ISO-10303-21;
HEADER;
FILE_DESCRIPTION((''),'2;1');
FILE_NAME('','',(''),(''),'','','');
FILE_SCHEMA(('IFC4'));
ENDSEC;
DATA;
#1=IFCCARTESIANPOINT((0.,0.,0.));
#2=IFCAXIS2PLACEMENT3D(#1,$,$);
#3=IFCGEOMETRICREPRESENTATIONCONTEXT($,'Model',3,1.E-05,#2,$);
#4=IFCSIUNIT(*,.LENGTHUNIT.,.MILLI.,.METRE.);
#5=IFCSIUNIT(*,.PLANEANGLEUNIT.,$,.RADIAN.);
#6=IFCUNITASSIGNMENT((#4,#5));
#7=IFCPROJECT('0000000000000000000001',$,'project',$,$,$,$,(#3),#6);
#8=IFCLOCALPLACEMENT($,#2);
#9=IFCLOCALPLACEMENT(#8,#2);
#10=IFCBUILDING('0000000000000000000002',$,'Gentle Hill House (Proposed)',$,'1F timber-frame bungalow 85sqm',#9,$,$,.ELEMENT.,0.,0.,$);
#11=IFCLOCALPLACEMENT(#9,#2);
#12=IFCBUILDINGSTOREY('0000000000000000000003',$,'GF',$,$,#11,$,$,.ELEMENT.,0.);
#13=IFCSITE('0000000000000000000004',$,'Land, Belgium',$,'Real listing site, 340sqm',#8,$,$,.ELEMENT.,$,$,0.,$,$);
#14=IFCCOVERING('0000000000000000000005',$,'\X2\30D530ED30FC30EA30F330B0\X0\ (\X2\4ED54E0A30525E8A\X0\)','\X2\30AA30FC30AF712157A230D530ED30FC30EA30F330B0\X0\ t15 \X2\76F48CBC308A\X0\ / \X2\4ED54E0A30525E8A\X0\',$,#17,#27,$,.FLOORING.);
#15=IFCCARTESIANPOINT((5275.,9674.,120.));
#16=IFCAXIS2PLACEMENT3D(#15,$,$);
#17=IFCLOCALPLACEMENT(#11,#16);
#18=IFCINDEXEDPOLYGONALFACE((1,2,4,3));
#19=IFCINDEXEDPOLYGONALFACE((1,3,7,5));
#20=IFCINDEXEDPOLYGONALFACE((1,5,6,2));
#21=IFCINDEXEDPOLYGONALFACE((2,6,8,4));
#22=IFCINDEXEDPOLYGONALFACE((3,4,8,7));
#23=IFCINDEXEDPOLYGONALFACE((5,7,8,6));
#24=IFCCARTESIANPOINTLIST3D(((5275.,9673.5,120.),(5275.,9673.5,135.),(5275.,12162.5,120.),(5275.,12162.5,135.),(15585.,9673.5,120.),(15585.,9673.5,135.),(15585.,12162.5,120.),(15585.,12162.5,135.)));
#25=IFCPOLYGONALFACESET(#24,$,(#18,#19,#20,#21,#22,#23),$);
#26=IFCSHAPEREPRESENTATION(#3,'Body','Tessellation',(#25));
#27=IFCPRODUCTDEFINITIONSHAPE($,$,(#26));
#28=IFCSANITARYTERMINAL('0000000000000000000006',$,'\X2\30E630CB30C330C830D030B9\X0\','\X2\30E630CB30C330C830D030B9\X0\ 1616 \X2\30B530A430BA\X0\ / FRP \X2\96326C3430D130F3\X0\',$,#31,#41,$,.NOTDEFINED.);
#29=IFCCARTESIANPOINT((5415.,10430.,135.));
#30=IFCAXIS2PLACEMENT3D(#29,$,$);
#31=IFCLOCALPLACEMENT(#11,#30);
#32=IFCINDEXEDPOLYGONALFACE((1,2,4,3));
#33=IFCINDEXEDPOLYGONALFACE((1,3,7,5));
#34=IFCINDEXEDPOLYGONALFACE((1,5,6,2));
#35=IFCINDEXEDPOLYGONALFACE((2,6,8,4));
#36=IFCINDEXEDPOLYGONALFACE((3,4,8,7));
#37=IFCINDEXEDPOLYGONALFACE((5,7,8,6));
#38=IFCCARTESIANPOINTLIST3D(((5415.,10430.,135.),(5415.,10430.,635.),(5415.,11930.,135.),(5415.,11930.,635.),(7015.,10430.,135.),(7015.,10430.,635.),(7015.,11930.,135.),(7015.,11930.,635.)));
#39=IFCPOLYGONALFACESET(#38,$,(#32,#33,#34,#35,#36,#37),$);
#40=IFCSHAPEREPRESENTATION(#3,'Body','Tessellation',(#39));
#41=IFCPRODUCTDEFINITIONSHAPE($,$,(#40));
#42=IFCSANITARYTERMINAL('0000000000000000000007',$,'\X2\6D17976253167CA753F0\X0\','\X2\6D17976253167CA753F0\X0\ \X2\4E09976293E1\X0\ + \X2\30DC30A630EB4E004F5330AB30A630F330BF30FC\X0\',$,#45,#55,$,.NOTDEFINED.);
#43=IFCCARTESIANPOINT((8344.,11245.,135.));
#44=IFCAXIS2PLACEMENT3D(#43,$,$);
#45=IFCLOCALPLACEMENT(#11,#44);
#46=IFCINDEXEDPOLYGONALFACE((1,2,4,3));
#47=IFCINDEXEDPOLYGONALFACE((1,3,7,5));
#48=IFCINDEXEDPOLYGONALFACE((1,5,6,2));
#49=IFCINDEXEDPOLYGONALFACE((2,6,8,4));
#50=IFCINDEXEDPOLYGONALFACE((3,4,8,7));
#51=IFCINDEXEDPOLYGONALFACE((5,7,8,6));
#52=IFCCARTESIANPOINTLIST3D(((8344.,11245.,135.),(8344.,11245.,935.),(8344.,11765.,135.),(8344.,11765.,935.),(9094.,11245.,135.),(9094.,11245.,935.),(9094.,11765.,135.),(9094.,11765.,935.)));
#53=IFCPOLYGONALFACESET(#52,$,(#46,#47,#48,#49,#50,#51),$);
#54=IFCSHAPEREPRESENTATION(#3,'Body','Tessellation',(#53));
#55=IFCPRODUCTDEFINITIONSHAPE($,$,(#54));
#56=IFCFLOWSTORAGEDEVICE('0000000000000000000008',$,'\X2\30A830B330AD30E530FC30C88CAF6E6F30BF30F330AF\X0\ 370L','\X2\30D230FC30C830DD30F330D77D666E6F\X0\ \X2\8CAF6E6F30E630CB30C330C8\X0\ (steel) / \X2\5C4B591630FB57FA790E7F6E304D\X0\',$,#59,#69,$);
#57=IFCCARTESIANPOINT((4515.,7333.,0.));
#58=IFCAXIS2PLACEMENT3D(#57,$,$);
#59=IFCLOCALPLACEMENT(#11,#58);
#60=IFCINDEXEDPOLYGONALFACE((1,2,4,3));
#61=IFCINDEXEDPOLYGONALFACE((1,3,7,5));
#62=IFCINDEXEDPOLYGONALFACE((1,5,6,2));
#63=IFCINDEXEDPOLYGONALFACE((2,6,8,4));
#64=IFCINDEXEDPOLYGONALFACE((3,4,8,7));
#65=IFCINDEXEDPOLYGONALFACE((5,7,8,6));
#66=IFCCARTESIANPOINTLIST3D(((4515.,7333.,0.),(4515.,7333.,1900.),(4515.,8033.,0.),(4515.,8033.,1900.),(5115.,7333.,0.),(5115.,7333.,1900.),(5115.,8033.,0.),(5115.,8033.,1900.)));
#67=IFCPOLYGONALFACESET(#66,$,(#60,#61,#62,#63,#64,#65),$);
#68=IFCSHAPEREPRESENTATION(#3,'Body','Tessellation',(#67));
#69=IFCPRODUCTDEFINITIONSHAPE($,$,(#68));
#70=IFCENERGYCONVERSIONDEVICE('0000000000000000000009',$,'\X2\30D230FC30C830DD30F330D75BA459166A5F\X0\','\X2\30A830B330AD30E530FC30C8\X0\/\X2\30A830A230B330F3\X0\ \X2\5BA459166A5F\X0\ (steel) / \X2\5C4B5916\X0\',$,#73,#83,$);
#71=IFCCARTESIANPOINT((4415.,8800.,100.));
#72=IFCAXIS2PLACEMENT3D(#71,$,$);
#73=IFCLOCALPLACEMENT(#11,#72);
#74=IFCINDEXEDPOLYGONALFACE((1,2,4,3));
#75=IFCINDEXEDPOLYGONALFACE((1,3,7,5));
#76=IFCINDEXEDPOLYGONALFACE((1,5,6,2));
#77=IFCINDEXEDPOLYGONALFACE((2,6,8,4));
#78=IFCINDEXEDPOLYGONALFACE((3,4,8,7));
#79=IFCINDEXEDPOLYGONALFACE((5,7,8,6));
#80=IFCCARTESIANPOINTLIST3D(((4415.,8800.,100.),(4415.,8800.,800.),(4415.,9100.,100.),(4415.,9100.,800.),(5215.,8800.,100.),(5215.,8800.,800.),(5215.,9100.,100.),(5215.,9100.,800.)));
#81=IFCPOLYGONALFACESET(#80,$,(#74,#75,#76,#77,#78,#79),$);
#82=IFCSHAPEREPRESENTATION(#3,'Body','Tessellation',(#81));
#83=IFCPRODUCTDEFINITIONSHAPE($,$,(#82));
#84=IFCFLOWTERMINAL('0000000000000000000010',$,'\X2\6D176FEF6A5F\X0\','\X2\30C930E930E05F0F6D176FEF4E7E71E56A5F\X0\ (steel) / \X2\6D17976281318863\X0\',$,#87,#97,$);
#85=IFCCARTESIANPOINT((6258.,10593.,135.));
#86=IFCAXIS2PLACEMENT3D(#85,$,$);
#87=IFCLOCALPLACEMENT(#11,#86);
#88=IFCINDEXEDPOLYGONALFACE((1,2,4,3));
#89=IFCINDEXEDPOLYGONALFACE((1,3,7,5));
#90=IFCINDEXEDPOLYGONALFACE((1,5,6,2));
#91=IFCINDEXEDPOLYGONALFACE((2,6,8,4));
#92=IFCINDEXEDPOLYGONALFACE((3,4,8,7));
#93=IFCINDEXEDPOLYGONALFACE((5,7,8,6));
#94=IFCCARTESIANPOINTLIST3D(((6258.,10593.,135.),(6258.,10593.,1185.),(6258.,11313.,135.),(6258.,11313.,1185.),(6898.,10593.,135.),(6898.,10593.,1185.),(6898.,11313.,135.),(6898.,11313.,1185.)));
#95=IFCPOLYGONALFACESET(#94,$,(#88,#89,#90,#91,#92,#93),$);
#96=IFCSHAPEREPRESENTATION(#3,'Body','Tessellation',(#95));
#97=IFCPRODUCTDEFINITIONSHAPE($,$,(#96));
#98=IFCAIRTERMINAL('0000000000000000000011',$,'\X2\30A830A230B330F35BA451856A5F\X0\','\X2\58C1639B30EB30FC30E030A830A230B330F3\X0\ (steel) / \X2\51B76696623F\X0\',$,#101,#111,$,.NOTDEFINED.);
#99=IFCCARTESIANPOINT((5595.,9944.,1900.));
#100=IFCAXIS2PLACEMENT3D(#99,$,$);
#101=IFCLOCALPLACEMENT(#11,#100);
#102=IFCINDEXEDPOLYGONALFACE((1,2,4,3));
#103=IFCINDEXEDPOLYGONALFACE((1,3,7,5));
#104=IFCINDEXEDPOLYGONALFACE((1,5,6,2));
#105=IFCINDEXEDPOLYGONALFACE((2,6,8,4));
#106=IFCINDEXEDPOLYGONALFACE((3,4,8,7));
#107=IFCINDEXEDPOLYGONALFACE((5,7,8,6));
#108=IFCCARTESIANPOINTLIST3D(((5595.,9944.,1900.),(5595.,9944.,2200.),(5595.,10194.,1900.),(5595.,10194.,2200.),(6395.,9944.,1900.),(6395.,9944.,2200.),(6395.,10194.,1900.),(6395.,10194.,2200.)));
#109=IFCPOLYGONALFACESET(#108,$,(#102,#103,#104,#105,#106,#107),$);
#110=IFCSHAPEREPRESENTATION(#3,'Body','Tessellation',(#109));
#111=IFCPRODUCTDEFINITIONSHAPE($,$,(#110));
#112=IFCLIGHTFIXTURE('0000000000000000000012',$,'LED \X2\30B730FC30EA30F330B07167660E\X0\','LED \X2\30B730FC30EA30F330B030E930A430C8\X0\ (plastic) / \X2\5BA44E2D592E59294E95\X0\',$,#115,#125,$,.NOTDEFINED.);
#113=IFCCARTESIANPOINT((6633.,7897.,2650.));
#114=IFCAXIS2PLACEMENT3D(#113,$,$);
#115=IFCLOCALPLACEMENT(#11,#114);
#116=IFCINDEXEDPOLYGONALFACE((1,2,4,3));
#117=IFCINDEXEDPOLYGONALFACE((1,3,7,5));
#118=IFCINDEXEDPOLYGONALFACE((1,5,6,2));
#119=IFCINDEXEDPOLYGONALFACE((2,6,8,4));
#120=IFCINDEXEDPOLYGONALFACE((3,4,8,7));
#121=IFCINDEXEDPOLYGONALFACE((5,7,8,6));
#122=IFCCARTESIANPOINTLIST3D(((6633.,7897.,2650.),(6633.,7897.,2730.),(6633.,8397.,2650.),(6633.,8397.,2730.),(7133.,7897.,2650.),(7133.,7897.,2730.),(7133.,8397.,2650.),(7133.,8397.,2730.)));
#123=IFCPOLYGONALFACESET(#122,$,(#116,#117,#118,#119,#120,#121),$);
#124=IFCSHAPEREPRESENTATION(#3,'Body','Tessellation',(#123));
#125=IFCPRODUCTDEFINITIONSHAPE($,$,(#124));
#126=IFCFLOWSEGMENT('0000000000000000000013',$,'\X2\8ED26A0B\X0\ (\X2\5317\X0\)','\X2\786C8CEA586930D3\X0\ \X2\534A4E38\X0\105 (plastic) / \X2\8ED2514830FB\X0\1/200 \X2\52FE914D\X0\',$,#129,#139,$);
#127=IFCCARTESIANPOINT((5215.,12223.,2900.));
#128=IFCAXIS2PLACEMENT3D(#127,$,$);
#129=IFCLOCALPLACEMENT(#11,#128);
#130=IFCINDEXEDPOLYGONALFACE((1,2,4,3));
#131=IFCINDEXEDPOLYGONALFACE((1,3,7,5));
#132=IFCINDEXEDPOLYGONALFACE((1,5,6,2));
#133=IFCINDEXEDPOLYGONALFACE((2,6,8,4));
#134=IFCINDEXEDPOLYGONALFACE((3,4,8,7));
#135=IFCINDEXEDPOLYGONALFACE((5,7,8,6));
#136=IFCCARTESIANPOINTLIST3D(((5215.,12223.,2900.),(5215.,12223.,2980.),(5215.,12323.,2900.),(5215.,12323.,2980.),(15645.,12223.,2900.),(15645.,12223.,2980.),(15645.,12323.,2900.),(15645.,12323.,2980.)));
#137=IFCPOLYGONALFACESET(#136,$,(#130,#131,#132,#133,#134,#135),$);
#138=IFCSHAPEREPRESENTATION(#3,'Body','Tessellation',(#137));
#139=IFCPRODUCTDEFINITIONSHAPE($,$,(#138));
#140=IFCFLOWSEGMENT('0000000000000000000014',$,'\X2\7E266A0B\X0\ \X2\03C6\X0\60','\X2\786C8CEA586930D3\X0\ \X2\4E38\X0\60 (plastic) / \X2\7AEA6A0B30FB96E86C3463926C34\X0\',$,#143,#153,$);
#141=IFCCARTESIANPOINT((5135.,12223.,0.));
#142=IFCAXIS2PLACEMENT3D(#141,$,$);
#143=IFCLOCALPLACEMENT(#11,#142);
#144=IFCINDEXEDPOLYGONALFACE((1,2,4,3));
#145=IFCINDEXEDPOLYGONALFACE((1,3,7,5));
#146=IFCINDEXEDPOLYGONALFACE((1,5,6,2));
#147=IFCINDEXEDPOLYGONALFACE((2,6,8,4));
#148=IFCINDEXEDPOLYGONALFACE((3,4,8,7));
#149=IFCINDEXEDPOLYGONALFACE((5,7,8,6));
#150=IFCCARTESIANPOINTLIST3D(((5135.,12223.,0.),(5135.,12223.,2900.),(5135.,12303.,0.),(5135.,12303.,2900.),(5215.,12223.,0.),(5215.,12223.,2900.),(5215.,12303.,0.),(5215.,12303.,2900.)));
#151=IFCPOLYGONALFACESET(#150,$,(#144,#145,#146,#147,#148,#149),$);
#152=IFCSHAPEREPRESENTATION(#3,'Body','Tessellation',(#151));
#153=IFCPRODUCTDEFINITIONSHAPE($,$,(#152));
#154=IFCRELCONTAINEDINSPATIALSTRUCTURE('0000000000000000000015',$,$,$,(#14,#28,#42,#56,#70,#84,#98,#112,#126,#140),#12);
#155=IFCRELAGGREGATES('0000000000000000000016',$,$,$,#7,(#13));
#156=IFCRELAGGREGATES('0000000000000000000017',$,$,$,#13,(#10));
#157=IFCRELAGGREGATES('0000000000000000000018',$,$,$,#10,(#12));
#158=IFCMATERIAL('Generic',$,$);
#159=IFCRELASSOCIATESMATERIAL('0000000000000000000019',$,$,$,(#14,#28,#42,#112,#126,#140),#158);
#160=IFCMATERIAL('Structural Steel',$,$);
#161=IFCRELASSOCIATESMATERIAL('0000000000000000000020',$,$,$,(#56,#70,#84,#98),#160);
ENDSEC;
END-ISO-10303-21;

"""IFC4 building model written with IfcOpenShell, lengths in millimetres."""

from ifc_helpers import new_model, si_unit, frame, frame_2d, origin, place, context, project, spatial, rectangle, extrude, material, element, save


model = new_model("IFC4")

# Units and contexts
model_context = context("Model", 3, precision=1e-05, world=origin())
ifc_project = project(units=[si_unit("LENGTHUNIT", "METRE", prefix="MILLI"), si_unit("PLANEANGLEUNIT", "RADIAN")], contexts=[model_context])

# Site, building, storey
site_placement = place(None, origin())
site = spatial("IfcSite", under=ifc_project, at=site_placement, Name="Land, Belgium", ObjectType="Real listing site, 340sqm", CompositionType="ELEMENT", RefElevation=0.0)
building_placement = place(site_placement, origin())
building = spatial("IfcBuilding", under=site, at=building_placement, Name="Gentle Hill House (Proposed)", ObjectType="1F timber-frame bungalow 85sqm", CompositionType="ELEMENT", ElevationOfRefHeight=0.0, ElevationOfTerrain=0.0)
storey_placement = place(building_placement, origin())
storey = spatial("IfcBuildingStorey", under=building, at=storey_placement, Name="GF", CompositionType="ELEMENT", Elevation=0.0)

# Shared definitions
ifc_material_1 = material(Name="Structural Steel")

# Covering
ifc_material_2 = material(Name="Generic")
covering_1_placement = place(storey_placement, frame((5275.0, 9674.0, 120.0)))
element("IfcCovering", 1, at=covering_1_placement, inside=storey, material=ifc_material_2, Name="フローリング (仕上げ床)", Description="オーク無垢フローリング t15 直貼り / 仕上げ床", PredefinedType="FLOORING", context=model_context, shape_type="SweptSolid", body=[
    extrude(rectangle(XDim=10310.0, YDim=2489.0, at=frame_2d((5155.0, 1244.0))), frame((5275.0, 9674.0, 120.0)), (0.0, 0.0, 1.0), 15.0),
])

# Sanitary terminals
sanitary_terminal_1_placement = place(storey_placement, frame((5415.0, 10430.0, 135.0)))
element("IfcSanitaryTerminal", 2, at=sanitary_terminal_1_placement, inside=storey, material=ifc_material_2, Name="ユニットバス", Description="ユニットバス 1616 サイズ / FRP 防水パン", PredefinedType="NOTDEFINED", context=model_context, shape_type="SweptSolid", body=[
    extrude(rectangle(XDim=1600.0, YDim=1500.0, at=frame_2d((800.0, 750.0))), frame((5415.0, 10430.0, 135.0)), (0.0, 0.0, 1.0), 500.0),
])
sanitary_terminal_2_placement = place(storey_placement, frame((8344.0, 11245.0, 135.0)))
element("IfcSanitaryTerminal", 3, at=sanitary_terminal_2_placement, inside=storey, material=ifc_material_2, Name="洗面化粧台", Description="洗面化粧台 三面鏡 + ボウル一体カウンター", PredefinedType="NOTDEFINED", context=model_context, shape_type="SweptSolid", body=[
    extrude(rectangle(XDim=750.0, YDim=520.0, at=frame_2d((375.0, 260.0))), frame((8344.0, 11245.0, 135.0)), (0.0, 0.0, 1.0), 800.0),
])

# Flow storage device
flow_storage_device_placement = place(storey_placement, frame((4515.0, 7333.0, 0.0)))
element("IfcFlowStorageDevice", 4, at=flow_storage_device_placement, inside=storey, material=ifc_material_1, Name="エコキュート貯湯タンク 370L", Description="ヒートポンプ給湯 貯湯ユニット (steel) / 屋外・基礎置き", context=model_context, shape_type="SweptSolid", body=[
    extrude(rectangle(XDim=600.0, YDim=700.0, at=frame_2d((300.0, 350.0))), frame((4515.0, 7333.0, 0.0)), (0.0, 0.0, 1.0), 1900.0),
])

# Energy conversion device
energy_conversion_device_placement = place(storey_placement, frame((4415.0, 8800.0, 100.0)))
element("IfcEnergyConversionDevice", 5, at=energy_conversion_device_placement, inside=storey, material=ifc_material_1, Name="ヒートポンプ室外機", Description="エコキュート/エアコン 室外機 (steel) / 屋外", context=model_context, shape_type="SweptSolid", body=[
    extrude(rectangle(XDim=800.0, YDim=300.0, at=frame_2d((400.0, 150.0))), frame((4415.0, 8800.0, 100.0)), (0.0, 0.0, 1.0), 700.0),
])

# Flow terminal
flow_terminal_placement = place(storey_placement, frame((6258.0, 10593.0, 135.0)))
element("IfcFlowTerminal", 6, at=flow_terminal_placement, inside=storey, material=ifc_material_1, Name="洗濯機", Description="ドラム式洗濯乾燥機 (steel) / 洗面脱衣", context=model_context, shape_type="SweptSolid", body=[
    extrude(rectangle(XDim=640.0, YDim=720.0, at=frame_2d((320.0, 360.0))), frame((6258.0, 10593.0, 135.0)), (0.0, 0.0, 1.0), 1050.0),
])

# Air terminal
air_terminal_placement = place(storey_placement, frame((5595.0, 9944.0, 1900.0)))
element("IfcAirTerminal", 7, at=air_terminal_placement, inside=storey, material=ifc_material_1, Name="エアコン室内機", Description="壁掛ルームエアコン (steel) / 冷暖房", PredefinedType="NOTDEFINED", context=model_context, shape_type="SweptSolid", body=[
    extrude(rectangle(XDim=800.0, YDim=250.0, at=frame_2d((400.0, 125.0))), frame((5595.0, 9944.0, 1900.0)), (0.0, 0.0, 1.0), 300.0),
])

# Light fixture
light_fixture_placement = place(storey_placement, frame((6633.0, 7897.0, 2650.0)))
element("IfcLightFixture", 8, at=light_fixture_placement, inside=storey, material=ifc_material_2, Name="LED シーリング照明", Description="LED シーリングライト (plastic) / 室中央天井", PredefinedType="NOTDEFINED", context=model_context, shape_type="SweptSolid", body=[
    extrude(rectangle(XDim=500.0, YDim=500.0, at=frame_2d((250.0, 250.0))), frame((6633.0, 7897.0, 2650.0)), (0.0, 0.0, 1.0), 80.0),
])

# Flow segments
flow_segment_1_placement = place(storey_placement, frame((5215.0, 12223.0, 2900.0)))
element("IfcFlowSegment", 9, at=flow_segment_1_placement, inside=storey, material=ifc_material_2, Name="軒樋 (北)", Description="硬質塩ビ 半丸105 (plastic) / 軒先・1/200 勾配", context=model_context, shape_type="SweptSolid", body=[
    extrude(rectangle(XDim=10430.0, YDim=100.0, at=frame_2d((5215.0, 50.0))), frame((5215.0, 12223.0, 2900.0)), (0.0, 0.0, 1.0), 80.0),
])
flow_segment_2_placement = place(storey_placement, frame((5135.0, 12223.0, 0.0)))
element("IfcFlowSegment", 10, at=flow_segment_2_placement, inside=storey, material=ifc_material_2, Name="縦樋 φ60", Description="硬質塩ビ 丸60 (plastic) / 竪樋・雨水排水", context=model_context, shape_type="SweptSolid", body=[
    extrude(rectangle(XDim=80.0, YDim=80.0, at=frame_2d((40.0, 40.0))), frame((5135.0, 12223.0, 0.0)), (0.0, 0.0, 1.0), 2900.0),
])

save(model, "model.ifc")
